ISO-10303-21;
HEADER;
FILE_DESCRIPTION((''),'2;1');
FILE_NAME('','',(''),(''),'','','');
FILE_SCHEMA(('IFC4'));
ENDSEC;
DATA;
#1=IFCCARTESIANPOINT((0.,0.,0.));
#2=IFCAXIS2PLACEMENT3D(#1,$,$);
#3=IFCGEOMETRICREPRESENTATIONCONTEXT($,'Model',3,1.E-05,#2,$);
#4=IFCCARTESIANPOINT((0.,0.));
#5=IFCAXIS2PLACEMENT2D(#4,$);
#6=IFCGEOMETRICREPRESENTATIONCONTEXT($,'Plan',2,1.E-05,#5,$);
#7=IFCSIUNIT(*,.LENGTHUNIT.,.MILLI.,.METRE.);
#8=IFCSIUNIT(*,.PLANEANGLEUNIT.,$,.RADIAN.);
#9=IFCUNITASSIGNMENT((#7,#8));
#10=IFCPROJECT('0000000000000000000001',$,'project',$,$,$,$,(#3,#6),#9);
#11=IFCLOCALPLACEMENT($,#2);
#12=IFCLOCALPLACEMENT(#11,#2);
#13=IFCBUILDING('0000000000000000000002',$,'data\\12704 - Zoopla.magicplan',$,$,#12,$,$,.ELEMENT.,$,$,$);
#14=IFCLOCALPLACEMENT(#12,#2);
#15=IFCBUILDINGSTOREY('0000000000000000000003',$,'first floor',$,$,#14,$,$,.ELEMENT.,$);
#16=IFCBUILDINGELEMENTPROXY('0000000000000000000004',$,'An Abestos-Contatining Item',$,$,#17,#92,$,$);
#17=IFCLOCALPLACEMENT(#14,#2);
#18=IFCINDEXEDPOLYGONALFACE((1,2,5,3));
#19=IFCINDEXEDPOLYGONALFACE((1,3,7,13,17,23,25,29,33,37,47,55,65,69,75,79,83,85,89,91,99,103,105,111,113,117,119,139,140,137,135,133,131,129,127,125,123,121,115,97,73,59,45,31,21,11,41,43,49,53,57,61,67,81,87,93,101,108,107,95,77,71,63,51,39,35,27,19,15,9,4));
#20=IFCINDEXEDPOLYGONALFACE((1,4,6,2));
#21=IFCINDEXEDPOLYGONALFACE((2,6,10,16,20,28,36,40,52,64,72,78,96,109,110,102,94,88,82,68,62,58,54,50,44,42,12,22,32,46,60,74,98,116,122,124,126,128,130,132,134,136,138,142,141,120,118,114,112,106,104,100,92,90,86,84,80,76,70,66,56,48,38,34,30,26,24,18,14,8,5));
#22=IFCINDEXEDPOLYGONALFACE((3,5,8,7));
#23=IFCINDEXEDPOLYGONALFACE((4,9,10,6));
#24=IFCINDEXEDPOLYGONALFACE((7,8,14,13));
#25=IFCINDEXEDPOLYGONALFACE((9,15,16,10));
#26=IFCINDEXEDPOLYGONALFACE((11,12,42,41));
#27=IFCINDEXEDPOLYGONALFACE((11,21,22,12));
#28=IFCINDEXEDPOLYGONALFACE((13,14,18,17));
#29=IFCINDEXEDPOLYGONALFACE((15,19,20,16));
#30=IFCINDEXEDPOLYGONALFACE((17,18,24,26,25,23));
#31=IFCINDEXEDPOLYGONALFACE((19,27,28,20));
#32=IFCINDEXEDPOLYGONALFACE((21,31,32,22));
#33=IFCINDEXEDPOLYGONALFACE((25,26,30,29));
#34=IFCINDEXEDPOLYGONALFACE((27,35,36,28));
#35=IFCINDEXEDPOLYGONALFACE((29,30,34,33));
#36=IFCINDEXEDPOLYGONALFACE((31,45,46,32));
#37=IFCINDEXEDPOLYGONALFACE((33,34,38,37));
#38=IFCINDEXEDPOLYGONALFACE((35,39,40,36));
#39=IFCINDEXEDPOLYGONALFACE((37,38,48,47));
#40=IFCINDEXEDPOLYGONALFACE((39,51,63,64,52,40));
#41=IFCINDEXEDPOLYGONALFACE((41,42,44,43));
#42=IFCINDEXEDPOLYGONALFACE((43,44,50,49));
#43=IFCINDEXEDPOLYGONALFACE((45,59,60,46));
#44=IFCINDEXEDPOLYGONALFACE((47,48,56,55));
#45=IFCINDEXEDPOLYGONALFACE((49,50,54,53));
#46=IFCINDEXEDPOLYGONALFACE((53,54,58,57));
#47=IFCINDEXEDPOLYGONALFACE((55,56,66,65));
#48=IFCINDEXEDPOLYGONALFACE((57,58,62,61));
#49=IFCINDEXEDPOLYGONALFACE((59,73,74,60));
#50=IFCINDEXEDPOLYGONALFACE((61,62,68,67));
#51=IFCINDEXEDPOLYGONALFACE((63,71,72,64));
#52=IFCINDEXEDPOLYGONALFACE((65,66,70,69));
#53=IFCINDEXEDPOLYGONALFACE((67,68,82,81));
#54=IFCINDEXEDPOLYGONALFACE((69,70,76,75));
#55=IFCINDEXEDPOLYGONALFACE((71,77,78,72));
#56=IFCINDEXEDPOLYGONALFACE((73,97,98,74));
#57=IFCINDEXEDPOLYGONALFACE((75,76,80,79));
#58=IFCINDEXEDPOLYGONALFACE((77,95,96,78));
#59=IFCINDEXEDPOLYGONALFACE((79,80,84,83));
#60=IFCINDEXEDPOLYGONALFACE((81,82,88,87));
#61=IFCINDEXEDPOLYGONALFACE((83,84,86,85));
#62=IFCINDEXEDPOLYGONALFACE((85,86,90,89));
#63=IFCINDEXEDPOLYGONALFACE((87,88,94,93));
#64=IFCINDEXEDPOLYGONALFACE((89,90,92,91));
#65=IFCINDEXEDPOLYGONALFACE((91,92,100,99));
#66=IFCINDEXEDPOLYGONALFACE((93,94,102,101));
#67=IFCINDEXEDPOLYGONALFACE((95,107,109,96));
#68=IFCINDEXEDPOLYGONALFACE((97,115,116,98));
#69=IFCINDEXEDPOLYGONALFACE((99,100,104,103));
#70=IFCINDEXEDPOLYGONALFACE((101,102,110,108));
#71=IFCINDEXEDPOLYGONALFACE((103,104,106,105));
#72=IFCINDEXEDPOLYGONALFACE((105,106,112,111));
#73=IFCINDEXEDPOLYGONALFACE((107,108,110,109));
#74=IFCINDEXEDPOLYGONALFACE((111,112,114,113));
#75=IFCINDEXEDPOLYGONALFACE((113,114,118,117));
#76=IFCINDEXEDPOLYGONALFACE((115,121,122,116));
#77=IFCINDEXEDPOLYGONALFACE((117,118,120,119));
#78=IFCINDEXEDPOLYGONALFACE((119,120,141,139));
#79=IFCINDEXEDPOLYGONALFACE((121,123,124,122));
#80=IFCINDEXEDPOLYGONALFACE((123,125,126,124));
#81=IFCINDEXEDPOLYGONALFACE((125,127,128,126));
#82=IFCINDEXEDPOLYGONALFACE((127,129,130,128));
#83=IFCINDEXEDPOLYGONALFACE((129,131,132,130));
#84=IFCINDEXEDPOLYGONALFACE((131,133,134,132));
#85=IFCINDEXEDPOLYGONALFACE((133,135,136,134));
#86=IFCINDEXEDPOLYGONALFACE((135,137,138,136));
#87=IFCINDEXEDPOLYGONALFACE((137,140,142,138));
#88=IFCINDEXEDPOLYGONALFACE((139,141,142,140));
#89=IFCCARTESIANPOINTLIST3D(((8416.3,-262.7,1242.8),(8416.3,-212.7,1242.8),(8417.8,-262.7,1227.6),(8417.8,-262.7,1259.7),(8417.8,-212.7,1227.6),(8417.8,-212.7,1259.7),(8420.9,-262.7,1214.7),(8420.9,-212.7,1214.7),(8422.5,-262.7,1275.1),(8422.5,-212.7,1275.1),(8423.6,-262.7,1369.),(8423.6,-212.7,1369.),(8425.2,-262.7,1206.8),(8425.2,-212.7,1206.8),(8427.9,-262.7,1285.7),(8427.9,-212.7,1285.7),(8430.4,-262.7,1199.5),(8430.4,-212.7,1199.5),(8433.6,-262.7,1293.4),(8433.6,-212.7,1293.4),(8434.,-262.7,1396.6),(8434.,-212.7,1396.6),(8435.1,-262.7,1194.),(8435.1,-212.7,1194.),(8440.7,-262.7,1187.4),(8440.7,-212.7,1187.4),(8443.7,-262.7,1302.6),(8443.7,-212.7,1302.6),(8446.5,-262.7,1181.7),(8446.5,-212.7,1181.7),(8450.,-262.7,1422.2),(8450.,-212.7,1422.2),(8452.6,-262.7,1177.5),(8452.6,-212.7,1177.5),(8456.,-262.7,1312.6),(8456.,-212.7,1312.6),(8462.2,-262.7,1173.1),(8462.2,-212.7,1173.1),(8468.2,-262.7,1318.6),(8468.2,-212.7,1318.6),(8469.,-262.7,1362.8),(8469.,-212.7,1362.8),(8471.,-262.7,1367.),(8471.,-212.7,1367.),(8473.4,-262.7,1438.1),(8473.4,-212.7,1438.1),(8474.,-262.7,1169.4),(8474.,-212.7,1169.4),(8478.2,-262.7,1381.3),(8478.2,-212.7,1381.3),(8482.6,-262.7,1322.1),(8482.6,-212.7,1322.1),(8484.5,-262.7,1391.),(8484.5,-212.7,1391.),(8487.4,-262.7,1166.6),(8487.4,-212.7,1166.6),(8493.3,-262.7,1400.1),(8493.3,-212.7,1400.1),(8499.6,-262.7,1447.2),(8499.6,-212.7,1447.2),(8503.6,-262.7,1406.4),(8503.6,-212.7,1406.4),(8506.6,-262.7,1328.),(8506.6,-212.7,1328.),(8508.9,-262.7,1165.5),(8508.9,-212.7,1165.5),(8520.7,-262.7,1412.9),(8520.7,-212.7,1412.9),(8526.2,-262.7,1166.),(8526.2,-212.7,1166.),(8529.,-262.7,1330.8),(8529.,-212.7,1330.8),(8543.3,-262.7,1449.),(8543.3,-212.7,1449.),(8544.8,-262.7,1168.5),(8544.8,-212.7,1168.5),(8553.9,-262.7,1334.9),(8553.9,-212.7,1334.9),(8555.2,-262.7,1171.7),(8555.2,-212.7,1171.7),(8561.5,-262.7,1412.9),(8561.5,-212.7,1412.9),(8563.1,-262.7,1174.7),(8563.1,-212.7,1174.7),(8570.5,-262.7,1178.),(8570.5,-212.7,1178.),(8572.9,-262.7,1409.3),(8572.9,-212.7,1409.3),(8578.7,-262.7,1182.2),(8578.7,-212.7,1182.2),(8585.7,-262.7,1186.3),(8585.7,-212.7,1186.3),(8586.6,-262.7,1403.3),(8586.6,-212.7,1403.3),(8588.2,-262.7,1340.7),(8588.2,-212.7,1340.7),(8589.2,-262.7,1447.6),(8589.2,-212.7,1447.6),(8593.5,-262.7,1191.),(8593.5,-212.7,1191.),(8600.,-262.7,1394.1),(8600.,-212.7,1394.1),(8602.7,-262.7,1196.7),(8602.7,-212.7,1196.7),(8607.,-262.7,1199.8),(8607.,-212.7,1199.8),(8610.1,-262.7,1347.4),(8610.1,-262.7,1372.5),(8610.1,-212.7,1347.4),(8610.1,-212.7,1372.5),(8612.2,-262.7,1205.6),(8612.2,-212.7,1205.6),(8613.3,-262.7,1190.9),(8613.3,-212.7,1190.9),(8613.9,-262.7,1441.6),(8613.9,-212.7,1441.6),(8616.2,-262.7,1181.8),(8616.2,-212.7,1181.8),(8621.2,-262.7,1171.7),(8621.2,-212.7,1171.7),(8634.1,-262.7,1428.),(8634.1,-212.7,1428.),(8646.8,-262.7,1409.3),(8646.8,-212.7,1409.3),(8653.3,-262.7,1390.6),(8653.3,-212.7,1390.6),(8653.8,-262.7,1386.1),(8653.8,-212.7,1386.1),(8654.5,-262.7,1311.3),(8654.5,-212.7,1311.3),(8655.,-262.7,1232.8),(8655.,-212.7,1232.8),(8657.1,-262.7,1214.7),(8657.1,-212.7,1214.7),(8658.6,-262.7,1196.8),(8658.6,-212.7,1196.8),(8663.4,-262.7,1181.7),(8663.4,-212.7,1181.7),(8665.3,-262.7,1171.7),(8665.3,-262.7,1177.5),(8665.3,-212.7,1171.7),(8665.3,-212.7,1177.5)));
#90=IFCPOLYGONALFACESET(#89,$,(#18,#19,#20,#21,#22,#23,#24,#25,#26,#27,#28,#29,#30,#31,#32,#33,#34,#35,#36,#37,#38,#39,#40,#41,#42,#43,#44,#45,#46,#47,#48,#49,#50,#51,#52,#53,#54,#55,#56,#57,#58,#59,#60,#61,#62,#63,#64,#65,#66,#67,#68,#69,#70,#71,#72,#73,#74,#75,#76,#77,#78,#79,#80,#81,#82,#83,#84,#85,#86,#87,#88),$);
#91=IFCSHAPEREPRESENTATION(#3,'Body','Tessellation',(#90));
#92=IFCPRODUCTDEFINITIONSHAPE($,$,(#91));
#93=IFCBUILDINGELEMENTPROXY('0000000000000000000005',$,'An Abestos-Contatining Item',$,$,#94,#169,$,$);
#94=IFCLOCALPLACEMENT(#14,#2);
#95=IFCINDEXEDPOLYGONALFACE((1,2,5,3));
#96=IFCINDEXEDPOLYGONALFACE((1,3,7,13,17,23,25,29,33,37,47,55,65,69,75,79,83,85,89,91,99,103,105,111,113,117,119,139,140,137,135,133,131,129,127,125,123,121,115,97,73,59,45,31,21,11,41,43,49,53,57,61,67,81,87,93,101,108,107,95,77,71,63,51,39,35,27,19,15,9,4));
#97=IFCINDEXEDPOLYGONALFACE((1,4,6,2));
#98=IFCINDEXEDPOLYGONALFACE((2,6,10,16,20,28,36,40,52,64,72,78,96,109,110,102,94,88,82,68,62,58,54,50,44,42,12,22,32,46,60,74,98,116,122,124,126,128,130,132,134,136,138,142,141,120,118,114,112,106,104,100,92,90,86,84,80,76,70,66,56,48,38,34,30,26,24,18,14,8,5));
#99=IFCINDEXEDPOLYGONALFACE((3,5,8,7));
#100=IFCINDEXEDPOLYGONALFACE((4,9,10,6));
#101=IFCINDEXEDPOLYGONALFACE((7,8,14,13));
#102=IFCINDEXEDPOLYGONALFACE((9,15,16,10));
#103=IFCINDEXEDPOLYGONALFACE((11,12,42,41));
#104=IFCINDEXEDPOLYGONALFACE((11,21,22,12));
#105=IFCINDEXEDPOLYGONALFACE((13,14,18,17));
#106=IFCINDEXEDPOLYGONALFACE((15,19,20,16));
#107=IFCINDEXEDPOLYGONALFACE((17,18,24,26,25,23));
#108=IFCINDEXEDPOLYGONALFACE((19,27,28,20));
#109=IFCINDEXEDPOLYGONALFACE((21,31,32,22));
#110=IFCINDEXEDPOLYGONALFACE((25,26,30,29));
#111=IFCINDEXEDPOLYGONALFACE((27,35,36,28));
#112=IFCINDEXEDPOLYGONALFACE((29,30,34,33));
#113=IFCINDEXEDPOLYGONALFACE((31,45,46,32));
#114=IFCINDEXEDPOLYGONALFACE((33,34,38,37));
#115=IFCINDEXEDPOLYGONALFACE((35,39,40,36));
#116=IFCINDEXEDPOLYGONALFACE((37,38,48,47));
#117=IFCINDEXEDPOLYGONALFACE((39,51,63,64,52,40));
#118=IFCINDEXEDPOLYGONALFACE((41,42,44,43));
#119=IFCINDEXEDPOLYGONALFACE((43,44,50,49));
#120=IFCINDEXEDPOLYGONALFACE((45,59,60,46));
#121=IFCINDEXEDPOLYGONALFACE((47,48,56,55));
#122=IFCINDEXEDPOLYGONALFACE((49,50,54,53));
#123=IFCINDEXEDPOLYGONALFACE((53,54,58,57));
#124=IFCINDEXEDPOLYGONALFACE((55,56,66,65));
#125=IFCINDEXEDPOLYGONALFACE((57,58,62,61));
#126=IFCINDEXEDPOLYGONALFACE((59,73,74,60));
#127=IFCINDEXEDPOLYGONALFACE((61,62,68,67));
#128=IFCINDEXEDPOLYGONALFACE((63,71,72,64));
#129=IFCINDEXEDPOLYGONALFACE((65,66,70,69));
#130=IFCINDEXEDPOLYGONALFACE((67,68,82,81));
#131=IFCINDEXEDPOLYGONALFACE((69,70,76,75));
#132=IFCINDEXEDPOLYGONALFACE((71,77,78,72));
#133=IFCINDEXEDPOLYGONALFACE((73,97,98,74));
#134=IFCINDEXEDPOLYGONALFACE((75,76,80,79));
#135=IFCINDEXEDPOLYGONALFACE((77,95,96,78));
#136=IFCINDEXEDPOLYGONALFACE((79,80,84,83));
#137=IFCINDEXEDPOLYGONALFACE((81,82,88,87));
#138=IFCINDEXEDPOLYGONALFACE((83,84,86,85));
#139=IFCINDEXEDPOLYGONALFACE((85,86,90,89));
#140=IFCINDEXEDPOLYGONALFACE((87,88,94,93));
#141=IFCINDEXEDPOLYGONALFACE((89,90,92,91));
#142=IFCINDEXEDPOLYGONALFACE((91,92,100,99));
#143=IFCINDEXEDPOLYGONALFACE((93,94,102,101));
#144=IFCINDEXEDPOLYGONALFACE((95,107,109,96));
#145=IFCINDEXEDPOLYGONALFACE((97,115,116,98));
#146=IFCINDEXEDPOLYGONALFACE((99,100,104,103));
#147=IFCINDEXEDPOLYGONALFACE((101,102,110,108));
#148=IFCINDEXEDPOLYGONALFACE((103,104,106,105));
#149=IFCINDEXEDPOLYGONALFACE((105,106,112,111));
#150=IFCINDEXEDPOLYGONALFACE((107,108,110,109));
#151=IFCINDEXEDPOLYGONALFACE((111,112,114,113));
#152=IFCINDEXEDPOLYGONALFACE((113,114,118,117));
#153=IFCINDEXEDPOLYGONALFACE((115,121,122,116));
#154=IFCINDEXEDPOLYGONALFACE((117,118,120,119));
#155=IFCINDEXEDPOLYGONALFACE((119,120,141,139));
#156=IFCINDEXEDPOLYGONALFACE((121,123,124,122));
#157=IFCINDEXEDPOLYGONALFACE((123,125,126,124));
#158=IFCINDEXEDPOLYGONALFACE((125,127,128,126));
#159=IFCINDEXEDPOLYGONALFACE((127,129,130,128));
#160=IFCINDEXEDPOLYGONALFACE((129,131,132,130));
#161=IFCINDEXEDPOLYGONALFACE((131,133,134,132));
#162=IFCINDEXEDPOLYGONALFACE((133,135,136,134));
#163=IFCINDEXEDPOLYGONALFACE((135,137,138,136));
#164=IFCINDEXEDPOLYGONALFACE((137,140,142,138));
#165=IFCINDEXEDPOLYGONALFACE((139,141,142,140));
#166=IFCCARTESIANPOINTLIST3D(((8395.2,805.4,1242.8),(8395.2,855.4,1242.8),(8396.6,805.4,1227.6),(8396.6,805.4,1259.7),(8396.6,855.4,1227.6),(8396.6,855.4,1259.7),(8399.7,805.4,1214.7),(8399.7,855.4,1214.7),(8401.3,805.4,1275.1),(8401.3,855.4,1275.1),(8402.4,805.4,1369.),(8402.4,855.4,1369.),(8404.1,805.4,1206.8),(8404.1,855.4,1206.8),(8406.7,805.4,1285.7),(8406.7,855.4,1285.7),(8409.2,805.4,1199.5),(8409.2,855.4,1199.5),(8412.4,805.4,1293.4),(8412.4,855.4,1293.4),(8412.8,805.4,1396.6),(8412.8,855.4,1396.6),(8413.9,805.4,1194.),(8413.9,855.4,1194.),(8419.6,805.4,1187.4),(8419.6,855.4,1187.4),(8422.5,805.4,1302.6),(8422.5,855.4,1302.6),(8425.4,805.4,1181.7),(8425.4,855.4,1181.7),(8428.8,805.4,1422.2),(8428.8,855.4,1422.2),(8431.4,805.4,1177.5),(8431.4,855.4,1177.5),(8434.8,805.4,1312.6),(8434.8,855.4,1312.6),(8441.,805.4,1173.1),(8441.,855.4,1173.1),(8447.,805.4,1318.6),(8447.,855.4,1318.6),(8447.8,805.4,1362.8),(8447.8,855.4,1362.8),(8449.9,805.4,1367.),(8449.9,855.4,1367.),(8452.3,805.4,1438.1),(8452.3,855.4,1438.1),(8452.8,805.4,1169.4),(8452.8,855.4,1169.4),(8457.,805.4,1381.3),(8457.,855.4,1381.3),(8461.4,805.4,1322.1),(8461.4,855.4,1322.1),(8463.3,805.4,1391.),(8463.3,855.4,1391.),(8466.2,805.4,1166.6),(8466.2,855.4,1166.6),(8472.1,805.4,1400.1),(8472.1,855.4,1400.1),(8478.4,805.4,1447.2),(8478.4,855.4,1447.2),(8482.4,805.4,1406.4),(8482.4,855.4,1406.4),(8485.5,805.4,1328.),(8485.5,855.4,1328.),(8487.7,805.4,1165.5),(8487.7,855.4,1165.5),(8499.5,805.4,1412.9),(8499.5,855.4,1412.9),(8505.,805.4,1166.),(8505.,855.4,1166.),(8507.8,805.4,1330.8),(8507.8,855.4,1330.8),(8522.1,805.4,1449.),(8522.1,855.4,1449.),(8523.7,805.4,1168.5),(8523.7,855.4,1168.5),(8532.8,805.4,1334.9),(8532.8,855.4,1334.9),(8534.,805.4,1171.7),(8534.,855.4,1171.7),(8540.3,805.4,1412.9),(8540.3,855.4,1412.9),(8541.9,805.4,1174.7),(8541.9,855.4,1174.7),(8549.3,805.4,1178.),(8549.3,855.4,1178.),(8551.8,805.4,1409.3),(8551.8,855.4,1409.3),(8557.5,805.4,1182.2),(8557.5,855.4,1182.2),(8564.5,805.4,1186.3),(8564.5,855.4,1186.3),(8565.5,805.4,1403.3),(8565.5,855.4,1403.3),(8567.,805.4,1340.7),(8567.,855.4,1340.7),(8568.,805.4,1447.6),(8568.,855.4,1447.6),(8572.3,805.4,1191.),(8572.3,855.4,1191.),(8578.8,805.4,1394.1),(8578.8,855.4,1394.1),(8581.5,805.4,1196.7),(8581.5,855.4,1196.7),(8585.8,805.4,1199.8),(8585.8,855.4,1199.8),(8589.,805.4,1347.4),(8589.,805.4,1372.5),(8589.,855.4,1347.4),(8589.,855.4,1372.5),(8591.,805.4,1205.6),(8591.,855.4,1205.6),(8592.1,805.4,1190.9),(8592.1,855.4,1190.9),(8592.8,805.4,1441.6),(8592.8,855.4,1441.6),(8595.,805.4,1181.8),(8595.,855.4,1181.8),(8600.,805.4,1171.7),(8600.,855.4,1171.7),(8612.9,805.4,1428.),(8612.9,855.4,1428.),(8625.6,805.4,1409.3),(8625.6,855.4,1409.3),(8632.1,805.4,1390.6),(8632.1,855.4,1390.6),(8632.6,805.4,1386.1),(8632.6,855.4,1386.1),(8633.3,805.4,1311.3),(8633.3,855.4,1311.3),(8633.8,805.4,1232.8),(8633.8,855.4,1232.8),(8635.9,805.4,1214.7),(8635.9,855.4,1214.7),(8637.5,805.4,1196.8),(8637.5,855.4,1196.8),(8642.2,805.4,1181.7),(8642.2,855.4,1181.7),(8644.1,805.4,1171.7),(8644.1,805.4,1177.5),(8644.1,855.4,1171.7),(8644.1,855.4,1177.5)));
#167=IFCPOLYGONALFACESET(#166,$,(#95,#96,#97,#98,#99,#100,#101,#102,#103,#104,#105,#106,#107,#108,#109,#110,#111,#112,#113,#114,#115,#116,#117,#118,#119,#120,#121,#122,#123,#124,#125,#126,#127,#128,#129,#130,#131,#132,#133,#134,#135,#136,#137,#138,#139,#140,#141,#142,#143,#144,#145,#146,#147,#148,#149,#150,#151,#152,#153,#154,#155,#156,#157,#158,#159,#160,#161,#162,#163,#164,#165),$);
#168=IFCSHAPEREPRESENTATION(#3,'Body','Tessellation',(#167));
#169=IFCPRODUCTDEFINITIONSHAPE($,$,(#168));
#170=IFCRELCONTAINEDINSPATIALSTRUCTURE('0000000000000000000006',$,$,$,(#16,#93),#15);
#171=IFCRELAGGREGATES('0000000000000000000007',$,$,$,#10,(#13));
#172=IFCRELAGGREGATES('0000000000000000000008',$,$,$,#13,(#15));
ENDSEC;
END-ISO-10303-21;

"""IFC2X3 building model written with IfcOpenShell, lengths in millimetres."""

from ifc_helpers import new_model, si_unit, frame, origin, origin_2d, place, context, project, spatial, polyline, outline, extrude, element, save


model = new_model("IFC2X3")

# Units and contexts
model_context = context("Model", 3, precision=1e-05, world=origin())
plan_context = context("Plan", 2, precision=1e-05, world=origin_2d())
ifc_project = project(units=[si_unit("LENGTHUNIT", "METRE", prefix="MILLI"), si_unit("PLANEANGLEUNIT", "RADIAN")], contexts=[model_context, plan_context])

# Building, storey
placement_1 = place(None, origin())
building_placement = place(placement_1, origin())
building = spatial("IfcBuilding", under=ifc_project, at=building_placement, Name="data\\12704 - Zoopla.magicplan", CompositionType="ELEMENT")
storey_placement = place(building_placement, origin())
storey = spatial("IfcBuildingStorey", under=building, at=storey_placement, Name="first floor", CompositionType="ELEMENT")

# Building element proxies
placement_2 = place(None, frame((8415.3, -212.7, 0.0)))
proxy_1_placement = place(placement_2, frame((0.0, 0.0, 1165.0)))
element("IfcBuildingElementProxy", 1, at=proxy_1_placement, inside=storey, Name="An Abestos-Contatining Item", context=model_context, shape_type="SurfaceModel", body=[
    extrude(outline(polyline([(239.2, 0.0, 146.3), (239.7, 0.0, 67.8), (241.8, 0.0, 49.7), (243.3, 0.0, 31.9), (248.1, 0.0, 16.7), (250.0, 0.0, 12.5), (250.0, 0.0, 6.7), (205.8, 0.0, 6.7), (200.9, 0.0, 16.8), (197.9, 0.0, 25.9), (196.9, 0.0, 40.6), (191.6, 0.0, 34.8), (187.3, 0.0, 31.7), (178.2, 0.0, 26.0), (170.3, 0.0, 21.3), (163.4, 0.0, 17.2), (155.2, 0.0, 13.0), (147.8, 0.0, 9.7), (139.9, 0.0, 6.7), (129.5, 0.0, 3.5), (110.9, 0.0, 1.0), (93.6, 0.0, 0.5), (72.1, 0.0, 1.6), (58.6, 0.0, 4.4), (46.9, 0.0, 8.1), (37.3, 0.0, 12.5), (31.2, 0.0, 16.7), (25.4, 0.0, 22.4), (19.8, 0.0, 29.0), (15.1, 0.0, 34.5), (9.9, 0.0, 41.9), (5.5, 0.0, 49.7), (2.5, 0.0, 62.6), (1.0, 0.0, 77.8), (2.5, 0.0, 94.7), (7.2, 0.0, 110.1), (12.6, 0.0, 120.7), (18.2, 0.0, 128.4), (28.4, 0.0, 137.6), (40.7, 0.0, 147.6), (52.9, 0.0, 153.6), (67.3, 0.0, 157.1), (91.3, 0.0, 163.0), (113.7, 0.0, 165.8), (138.6, 0.0, 169.9), (172.9, 0.0, 175.7), (194.8, 0.0, 182.4), (194.8, 0.0, 207.5), (184.7, 0.0, 229.1), (171.3, 0.0, 238.3), (157.6, 0.0, 244.3), (146.2, 0.0, 247.9), (105.3, 0.0, 247.9), (88.3, 0.0, 241.4), (77.9, 0.0, 235.1), (69.1, 0.0, 226.0), (62.9, 0.0, 216.3), (55.7, 0.0, 202.0), (53.6, 0.0, 197.8), (8.2, 0.0, 204.0), (18.7, 0.0, 231.7), (34.6, 0.0, 257.2), (58.1, 0.0, 273.1), (84.2, 0.0, 282.2), (128.0, 0.0, 284.0), (173.9, 0.0, 282.6), (198.6, 0.0, 276.6), (218.8, 0.0, 263.1), (231.4, 0.0, 244.3), (238.0, 0.0, 225.6), (238.5, 0.0, 221.1)]), holes=[polyline([(193.0, 0.0, 144.2), (193.0, 0.0, 117.7), (190.5, 0.0, 97.8), (183.8, 0.0, 80.4), (174.2, 0.0, 64.5), (165.3, 0.0, 54.4), (152.5, 0.0, 47.3), (138.0, 0.0, 41.5), (124.6, 0.0, 37.8), (85.5, 0.0, 37.8), (75.0, 0.0, 41.4), (65.8, 0.0, 47.1), (57.8, 0.0, 55.4), (52.1, 0.0, 66.4), (49.5, 0.0, 74.4), (49.5, 0.0, 88.6), (55.3, 0.0, 100.7), (65.3, 0.0, 109.9), (81.0, 0.0, 119.8), (101.0, 0.0, 125.3), (119.9, 0.0, 128.5), (146.8, 0.0, 131.5), (165.0, 0.0, 134.9), (179.8, 0.0, 140.1), (193.0, 0.0, 144.2)])], kind="CURVE"), origin(), (0.0, -1.0, 0.0), 50.0),
])
placement_3 = place(None, frame((8415.3, -212.7, 0.0)))
proxy_2_placement = place(placement_3, frame((-21.2, 1068.1, 1165.0)))
element("IfcBuildingElementProxy", 2, at=proxy_2_placement, inside=storey, Name="An Abestos-Contatining Item", context=model_context, shape_type="SurfaceModel", body=[
    extrude(outline(polyline([(239.2, 0.0, 146.3), (239.7, 0.0, 67.8), (241.8, 0.0, 49.7), (243.3, 0.0, 31.9), (248.1, 0.0, 16.7), (250.0, 0.0, 12.5), (250.0, 0.0, 6.7), (205.8, 0.0, 6.7), (200.9, 0.0, 16.8), (197.9, 0.0, 25.9), (196.9, 0.0, 40.6), (191.6, 0.0, 34.8), (187.3, 0.0, 31.7), (178.2, 0.0, 26.0), (170.3, 0.0, 21.3), (163.4, 0.0, 17.2), (155.2, 0.0, 13.0), (147.8, 0.0, 9.7), (139.9, 0.0, 6.7), (129.5, 0.0, 3.5), (110.9, 0.0, 1.0), (93.6, 0.0, 0.5), (72.1, 0.0, 1.6), (58.6, 0.0, 4.4), (46.9, 0.0, 8.1), (37.3, 0.0, 12.5), (31.2, 0.0, 16.7), (25.4, 0.0, 22.4), (19.8, 0.0, 29.0), (15.1, 0.0, 34.5), (9.9, 0.0, 41.9), (5.5, 0.0, 49.7), (2.5, 0.0, 62.6), (1.0, 0.0, 77.8), (2.5, 0.0, 94.7), (7.2, 0.0, 110.1), (12.6, 0.0, 120.7), (18.2, 0.0, 128.4), (28.4, 0.0, 137.6), (40.7, 0.0, 147.6), (52.9, 0.0, 153.6), (67.3, 0.0, 157.1), (91.3, 0.0, 163.0), (113.7, 0.0, 165.8), (138.6, 0.0, 169.9), (172.9, 0.0, 175.7), (194.8, 0.0, 182.4), (194.8, 0.0, 207.5), (184.7, 0.0, 229.1), (171.3, 0.0, 238.3), (157.6, 0.0, 244.3), (146.2, 0.0, 247.9), (105.3, 0.0, 247.9), (88.3, 0.0, 241.4), (77.9, 0.0, 235.1), (69.1, 0.0, 226.0), (62.9, 0.0, 216.3), (55.7, 0.0, 202.0), (53.6, 0.0, 197.8), (8.2, 0.0, 204.0), (18.7, 0.0, 231.7), (34.6, 0.0, 257.2), (58.1, 0.0, 273.1), (84.2, 0.0, 282.2), (128.0, 0.0, 284.0), (173.9, 0.0, 282.6), (198.6, 0.0, 276.6), (218.8, 0.0, 263.1), (231.4, 0.0, 244.3), (238.0, 0.0, 225.6), (238.5, 0.0, 221.1)]), holes=[polyline([(193.0, 0.0, 144.2), (193.0, 0.0, 117.7), (190.5, 0.0, 97.8), (183.8, 0.0, 80.4), (174.2, 0.0, 64.5), (165.3, 0.0, 54.4), (152.5, 0.0, 47.3), (138.0, 0.0, 41.5), (124.6, 0.0, 37.8), (85.5, 0.0, 37.8), (75.0, 0.0, 41.4), (65.8, 0.0, 47.1), (57.8, 0.0, 55.4), (52.1, 0.0, 66.4), (49.5, 0.0, 74.4), (49.5, 0.0, 88.6), (55.3, 0.0, 100.7), (65.3, 0.0, 109.9), (81.0, 0.0, 119.8), (101.0, 0.0, 125.3), (119.9, 0.0, 128.5), (146.8, 0.0, 131.5), (165.0, 0.0, 134.9), (179.8, 0.0, 140.1), (193.0, 0.0, 144.2)])], kind="CURVE"), origin(), (0.0, -1.0, 0.0), 50.0),
])

save(model, "model.ifc")
